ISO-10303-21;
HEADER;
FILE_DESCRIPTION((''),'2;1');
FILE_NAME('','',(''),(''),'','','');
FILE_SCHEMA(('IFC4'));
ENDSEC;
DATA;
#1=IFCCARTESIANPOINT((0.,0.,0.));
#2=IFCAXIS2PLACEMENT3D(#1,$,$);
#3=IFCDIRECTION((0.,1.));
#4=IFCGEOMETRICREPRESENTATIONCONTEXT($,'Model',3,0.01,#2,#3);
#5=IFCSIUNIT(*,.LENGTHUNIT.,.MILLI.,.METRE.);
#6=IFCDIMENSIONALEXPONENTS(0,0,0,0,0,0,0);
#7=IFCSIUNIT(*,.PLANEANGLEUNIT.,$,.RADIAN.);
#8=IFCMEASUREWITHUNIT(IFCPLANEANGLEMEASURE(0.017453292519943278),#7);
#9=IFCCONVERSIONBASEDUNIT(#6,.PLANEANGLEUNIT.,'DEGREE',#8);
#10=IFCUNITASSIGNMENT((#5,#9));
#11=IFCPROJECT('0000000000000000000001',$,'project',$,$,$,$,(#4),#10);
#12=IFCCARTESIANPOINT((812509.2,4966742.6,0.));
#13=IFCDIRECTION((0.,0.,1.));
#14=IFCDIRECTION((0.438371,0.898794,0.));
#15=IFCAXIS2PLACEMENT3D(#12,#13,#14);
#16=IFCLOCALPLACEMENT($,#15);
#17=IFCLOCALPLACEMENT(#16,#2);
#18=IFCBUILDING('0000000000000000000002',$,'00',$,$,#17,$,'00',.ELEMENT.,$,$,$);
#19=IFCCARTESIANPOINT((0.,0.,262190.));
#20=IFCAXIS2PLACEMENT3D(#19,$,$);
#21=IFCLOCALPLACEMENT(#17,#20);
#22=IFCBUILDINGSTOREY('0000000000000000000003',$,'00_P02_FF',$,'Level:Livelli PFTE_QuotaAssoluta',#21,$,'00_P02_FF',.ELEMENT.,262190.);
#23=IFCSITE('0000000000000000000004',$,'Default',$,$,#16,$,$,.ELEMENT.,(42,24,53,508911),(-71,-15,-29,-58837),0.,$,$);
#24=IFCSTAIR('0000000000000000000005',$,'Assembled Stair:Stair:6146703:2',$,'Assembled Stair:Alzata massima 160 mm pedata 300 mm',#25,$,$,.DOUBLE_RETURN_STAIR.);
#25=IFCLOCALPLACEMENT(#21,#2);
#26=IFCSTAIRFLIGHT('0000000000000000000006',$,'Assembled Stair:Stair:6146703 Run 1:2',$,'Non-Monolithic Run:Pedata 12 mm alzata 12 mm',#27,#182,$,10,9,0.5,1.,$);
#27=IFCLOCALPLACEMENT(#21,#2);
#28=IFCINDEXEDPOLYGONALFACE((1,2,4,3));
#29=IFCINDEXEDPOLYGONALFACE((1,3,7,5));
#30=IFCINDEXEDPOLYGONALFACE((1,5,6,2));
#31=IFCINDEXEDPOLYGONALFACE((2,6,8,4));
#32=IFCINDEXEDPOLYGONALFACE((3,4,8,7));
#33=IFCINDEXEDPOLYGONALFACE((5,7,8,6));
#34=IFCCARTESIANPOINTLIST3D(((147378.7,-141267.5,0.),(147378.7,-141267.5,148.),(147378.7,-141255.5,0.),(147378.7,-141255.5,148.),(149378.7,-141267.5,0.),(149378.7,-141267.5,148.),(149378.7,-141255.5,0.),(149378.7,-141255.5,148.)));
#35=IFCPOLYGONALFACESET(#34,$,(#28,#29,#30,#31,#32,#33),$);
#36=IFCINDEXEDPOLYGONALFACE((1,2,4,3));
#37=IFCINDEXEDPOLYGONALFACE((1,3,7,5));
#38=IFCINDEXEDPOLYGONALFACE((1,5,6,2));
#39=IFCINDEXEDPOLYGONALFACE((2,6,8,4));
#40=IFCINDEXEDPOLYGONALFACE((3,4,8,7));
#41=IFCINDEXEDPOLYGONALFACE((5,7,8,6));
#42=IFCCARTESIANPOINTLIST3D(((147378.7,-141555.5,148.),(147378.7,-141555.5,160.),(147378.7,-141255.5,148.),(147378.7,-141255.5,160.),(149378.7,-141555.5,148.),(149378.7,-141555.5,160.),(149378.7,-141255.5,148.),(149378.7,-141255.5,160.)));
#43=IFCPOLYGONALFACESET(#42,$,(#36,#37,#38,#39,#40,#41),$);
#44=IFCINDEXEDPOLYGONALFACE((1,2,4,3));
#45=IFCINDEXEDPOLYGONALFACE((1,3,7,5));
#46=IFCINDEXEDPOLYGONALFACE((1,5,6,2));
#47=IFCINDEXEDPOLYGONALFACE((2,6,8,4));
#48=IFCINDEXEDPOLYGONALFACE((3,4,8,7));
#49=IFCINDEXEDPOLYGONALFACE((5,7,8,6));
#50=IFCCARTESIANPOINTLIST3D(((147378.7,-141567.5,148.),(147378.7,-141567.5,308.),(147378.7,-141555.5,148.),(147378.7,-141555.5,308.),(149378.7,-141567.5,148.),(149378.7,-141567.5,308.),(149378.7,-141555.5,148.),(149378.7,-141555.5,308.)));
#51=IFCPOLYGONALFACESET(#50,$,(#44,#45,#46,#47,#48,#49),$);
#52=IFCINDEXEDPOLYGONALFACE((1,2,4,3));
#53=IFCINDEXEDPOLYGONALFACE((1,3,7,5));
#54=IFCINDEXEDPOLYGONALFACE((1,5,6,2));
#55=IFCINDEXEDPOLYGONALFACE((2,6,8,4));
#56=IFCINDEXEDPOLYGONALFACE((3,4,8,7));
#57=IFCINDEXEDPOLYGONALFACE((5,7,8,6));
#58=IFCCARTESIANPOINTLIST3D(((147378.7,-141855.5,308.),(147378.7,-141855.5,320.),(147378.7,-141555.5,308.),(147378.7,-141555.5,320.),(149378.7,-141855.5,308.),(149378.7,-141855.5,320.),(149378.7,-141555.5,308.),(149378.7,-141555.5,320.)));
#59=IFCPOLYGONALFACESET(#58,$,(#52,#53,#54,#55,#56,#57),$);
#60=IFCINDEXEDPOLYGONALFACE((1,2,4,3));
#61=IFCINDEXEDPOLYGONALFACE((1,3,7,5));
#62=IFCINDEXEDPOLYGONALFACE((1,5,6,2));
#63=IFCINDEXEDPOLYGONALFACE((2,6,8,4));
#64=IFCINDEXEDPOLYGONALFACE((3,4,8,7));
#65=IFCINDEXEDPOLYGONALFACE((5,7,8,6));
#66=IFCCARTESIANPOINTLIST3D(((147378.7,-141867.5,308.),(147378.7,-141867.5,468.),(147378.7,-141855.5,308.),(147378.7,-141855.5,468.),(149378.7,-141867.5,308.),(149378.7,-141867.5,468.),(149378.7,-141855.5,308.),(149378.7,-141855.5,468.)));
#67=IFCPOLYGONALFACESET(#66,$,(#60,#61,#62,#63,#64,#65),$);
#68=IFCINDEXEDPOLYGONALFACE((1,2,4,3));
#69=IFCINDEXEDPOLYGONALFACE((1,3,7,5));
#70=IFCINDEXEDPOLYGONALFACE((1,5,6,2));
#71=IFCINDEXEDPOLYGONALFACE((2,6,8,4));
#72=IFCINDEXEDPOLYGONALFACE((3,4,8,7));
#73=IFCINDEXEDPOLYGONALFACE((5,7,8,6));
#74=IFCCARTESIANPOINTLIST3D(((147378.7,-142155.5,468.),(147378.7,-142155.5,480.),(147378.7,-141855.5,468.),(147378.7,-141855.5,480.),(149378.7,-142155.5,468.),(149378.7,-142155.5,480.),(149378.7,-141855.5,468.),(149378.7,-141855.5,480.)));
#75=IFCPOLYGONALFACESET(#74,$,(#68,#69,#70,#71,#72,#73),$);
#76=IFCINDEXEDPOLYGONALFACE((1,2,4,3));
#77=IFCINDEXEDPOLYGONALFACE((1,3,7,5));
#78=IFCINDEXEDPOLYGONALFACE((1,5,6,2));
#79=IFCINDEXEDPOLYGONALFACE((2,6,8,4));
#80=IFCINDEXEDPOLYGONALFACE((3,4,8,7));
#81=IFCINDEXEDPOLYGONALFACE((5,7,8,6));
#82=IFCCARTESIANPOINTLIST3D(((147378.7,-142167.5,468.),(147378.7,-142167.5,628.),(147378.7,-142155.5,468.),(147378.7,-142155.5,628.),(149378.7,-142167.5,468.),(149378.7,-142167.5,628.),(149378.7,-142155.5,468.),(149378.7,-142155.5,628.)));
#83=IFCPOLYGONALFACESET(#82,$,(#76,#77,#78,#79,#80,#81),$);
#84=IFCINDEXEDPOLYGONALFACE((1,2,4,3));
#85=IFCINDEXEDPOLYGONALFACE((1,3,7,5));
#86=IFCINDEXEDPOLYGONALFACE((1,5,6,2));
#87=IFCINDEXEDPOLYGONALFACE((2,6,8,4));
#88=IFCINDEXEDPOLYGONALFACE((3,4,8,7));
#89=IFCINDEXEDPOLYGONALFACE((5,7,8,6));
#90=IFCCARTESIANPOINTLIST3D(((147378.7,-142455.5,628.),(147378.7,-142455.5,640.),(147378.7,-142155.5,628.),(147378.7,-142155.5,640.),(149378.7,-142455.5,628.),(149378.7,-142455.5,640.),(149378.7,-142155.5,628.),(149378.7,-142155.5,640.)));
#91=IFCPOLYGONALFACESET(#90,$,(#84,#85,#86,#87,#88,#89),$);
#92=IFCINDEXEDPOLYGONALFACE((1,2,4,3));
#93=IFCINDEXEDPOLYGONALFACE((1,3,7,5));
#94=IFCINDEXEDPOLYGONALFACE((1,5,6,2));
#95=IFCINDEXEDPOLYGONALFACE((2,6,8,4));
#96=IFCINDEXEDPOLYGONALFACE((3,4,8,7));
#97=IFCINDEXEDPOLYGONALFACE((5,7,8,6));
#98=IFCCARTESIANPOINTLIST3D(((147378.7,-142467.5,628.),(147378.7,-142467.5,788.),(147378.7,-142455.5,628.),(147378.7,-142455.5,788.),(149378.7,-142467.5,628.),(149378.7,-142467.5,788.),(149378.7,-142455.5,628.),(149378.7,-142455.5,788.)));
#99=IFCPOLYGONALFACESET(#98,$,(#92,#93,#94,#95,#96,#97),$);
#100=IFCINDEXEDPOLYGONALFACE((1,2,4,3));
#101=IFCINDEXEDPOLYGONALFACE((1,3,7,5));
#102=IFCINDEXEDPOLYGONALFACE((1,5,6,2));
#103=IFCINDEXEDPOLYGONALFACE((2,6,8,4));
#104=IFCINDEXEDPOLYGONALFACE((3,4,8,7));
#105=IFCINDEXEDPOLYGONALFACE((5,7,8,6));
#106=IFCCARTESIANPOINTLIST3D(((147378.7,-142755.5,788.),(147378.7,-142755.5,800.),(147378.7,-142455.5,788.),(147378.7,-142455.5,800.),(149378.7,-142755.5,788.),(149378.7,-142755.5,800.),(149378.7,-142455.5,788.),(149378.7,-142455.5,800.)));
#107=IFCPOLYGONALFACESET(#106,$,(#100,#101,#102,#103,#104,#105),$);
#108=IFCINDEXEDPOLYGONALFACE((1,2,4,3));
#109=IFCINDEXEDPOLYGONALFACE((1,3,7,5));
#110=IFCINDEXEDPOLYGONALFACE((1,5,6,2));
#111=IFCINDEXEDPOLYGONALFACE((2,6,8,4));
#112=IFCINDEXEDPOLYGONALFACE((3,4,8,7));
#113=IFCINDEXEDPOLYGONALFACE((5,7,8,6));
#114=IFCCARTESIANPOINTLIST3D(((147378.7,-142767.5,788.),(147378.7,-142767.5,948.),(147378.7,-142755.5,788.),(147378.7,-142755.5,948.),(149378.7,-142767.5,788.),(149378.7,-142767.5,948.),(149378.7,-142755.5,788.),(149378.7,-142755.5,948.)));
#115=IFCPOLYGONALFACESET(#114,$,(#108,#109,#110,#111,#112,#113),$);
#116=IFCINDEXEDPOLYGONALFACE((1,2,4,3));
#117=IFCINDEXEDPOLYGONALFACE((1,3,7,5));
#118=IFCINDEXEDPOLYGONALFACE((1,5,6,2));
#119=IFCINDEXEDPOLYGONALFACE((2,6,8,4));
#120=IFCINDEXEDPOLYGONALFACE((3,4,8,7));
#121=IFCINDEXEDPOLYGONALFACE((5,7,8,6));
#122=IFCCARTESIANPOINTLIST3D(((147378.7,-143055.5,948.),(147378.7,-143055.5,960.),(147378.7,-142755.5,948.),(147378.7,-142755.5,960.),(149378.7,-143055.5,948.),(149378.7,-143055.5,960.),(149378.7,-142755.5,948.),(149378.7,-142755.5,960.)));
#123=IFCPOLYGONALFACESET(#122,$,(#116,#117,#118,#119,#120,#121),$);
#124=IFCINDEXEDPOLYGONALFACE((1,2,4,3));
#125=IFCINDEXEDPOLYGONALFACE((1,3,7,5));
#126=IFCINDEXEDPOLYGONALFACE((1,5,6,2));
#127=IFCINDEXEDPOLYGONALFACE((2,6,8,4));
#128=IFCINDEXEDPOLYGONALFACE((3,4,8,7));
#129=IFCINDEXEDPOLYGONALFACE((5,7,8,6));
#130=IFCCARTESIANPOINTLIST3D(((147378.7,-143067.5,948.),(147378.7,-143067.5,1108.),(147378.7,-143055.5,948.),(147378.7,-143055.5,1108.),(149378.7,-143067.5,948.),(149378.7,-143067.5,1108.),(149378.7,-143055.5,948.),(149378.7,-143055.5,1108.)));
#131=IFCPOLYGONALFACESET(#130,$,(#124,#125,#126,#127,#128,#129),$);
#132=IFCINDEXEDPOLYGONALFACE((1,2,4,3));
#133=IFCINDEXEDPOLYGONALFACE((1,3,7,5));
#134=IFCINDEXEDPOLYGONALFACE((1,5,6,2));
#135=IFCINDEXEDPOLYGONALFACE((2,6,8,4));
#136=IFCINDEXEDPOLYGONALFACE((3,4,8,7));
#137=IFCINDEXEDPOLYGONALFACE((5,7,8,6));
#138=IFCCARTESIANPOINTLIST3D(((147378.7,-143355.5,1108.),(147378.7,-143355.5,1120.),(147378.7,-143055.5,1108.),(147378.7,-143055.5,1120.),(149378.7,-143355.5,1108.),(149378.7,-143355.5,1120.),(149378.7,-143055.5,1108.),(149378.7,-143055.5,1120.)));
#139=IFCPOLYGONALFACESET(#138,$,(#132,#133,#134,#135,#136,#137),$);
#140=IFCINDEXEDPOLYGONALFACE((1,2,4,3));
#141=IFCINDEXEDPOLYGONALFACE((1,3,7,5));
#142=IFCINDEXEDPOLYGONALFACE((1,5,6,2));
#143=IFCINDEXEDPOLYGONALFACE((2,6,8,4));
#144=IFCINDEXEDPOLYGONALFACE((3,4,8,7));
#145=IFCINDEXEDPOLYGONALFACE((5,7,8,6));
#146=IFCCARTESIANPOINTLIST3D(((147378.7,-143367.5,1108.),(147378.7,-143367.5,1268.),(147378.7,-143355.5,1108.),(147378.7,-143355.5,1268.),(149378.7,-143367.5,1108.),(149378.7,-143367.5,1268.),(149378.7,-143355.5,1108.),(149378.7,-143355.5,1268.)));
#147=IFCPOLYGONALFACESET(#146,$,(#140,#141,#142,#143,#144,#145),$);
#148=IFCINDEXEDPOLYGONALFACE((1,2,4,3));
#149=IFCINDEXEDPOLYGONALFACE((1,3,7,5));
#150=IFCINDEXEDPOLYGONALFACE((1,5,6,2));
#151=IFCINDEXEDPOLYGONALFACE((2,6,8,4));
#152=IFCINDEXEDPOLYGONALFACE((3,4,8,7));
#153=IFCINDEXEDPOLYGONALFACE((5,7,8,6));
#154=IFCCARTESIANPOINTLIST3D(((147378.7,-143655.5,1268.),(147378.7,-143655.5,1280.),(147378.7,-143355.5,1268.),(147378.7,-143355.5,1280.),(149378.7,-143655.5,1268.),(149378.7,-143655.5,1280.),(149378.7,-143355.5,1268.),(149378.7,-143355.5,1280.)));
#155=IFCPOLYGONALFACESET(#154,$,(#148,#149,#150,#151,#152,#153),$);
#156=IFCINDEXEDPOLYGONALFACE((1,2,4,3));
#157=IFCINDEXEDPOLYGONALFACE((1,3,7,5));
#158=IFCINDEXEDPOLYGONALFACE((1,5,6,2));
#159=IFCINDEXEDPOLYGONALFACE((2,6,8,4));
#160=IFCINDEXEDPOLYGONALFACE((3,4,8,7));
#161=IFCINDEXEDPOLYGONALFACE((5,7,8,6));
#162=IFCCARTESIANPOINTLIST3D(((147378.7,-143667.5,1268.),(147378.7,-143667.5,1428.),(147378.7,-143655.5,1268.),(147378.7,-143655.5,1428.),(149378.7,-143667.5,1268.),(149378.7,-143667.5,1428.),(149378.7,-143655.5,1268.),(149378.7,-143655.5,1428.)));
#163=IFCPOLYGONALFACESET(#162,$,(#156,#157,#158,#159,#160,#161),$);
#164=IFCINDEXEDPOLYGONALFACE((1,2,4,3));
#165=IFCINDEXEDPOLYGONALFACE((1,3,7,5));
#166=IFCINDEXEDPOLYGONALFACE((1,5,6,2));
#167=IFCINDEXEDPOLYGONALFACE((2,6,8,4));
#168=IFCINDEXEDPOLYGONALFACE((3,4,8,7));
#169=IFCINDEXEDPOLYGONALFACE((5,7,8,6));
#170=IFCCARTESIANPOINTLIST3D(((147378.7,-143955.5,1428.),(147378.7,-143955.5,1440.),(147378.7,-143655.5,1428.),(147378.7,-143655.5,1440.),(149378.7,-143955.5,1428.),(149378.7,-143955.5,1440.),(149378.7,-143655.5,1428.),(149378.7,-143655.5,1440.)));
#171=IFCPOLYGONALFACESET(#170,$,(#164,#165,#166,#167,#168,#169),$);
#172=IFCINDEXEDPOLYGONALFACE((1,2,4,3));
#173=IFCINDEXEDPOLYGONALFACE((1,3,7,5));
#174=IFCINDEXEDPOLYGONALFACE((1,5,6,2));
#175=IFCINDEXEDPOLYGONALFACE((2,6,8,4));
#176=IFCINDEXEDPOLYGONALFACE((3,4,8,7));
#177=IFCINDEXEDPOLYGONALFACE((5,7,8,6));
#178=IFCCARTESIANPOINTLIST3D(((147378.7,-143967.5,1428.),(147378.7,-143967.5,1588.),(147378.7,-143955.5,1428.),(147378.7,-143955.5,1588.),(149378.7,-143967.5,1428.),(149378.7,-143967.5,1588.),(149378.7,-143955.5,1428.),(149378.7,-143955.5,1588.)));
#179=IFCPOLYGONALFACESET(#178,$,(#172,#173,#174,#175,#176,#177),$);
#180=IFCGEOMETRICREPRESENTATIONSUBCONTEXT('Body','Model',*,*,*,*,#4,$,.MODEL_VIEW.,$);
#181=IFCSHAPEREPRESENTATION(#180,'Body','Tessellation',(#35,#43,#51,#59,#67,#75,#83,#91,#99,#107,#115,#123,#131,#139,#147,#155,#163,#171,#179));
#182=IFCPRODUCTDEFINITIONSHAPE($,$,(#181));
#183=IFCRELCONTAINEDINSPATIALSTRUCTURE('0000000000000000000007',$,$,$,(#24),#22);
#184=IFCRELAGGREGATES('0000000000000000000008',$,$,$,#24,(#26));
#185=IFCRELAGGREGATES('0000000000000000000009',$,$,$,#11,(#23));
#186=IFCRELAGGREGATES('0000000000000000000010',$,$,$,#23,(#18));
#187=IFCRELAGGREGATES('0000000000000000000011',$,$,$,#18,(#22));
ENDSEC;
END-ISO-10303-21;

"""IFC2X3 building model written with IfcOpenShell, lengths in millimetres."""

from ifc_helpers import new_model, entity, si_unit, converted_unit, direction, frame, frame_2d, origin, origin_2d_with_axis, place, context, subcontext, project, spatial, rectangle, extrude, element, aggregate, save


model = new_model("IFC2X3")

# Units and contexts
model_context = context("Model", 3, precision=0.01, world=origin(), true_north=direction((0.0, 1.0)))
body_context = subcontext(model_context, "Body", "Model", "MODEL_VIEW")
ifc_project = project(units=[si_unit("LENGTHUNIT", "METRE", prefix="MILLI"), converted_unit("PLANEANGLEUNIT", "DEGREE", entity("IfcPlaneAngleMeasure", 0.017453292519943278), si_unit("PLANEANGLEUNIT", "RADIAN"), dimensions=[0, 0, 0, 0, 0, 0, 0])], contexts=[model_context])

# Site, building, storey
site_placement = place(None, frame((812509.2, 4966742.6, 0.0), z_axis=(0.0, 0.0, 1.0), x_axis=(0.438371, 0.898794, 0.0)))
site = spatial("IfcSite", under=ifc_project, at=site_placement, Name="Default", CompositionType="ELEMENT", RefLatitude=(42, 24, 53, 508911), RefLongitude=(-71, -15, -29, -58837), RefElevation=0.0)
building_placement = place(site_placement, origin())
building = spatial("IfcBuilding", under=site, at=building_placement, Name="00", LongName="00", CompositionType="ELEMENT")
storey_placement = place(building_placement, frame((0.0, 0.0, 262190.0)))
storey = spatial("IfcBuildingStorey", under=building, at=storey_placement, Name="00_P02_FF", ObjectType="Level:Livelli PFTE_QuotaAssoluta", LongName="00_P02_FF", CompositionType="ELEMENT", Elevation=262190.0)

# Stair
stair_1_placement = place(storey_placement, origin())
stair_1 = element("IfcStair", 1, at=stair_1_placement, inside=storey, Name="Assembled Stair:Stair:6146703:2", ObjectType="Assembled Stair:Alzata massima 160 mm pedata 300 mm", ShapeType="DOUBLE_RETURN_STAIR")

# Stair flight
stair_flight_1_placement = place(stair_1_placement, origin())
stair_flight_1 = element("IfcStairFlight", 2, at=stair_flight_1_placement, Name="Assembled Stair:Stair:6146703 Run 1:2", ObjectType="Non-Monolithic Run:Pedata 12 mm alzata 12 mm", NumberOfRiser=10, NumberOfTreads=9, RiserHeight=0.5, TreadLength=1.0, context=body_context, shape_type="SweptSolid", body=[
    extrude(rectangle(XDim=2000.0, YDim=12.0, at=origin_2d_with_axis()), frame((148378.7, -141261.5, 0.0)), (0.0, 0.0, 1.0), 148.0),
    extrude(rectangle(XDim=300.0, YDim=2000.0, at=frame_2d((0.0, 0.0), x_axis=(1.0, 0.0))), frame((148378.7, -141405.5, 148.0), z_axis=(0.0, 0.0, 1.0), x_axis=(0.0, 1.0, 0.0)), (0.0, 0.0, 1.0), 12.0),
    extrude(rectangle(XDim=2000.0, YDim=12.0, at=origin_2d_with_axis()), frame((148378.7, -141561.5, 148.0)), (0.0, 0.0, 1.0), 160.0),
    extrude(rectangle(XDim=300.0, YDim=2000.0, at=origin_2d_with_axis()), frame((148378.7, -141705.5, 308.0), z_axis=(0.0, 0.0, 1.0), x_axis=(0.0, 1.0, 0.0)), (0.0, 0.0, 1.0), 12.0),
    extrude(rectangle(XDim=2000.0, YDim=12.0, at=origin_2d_with_axis()), frame((148378.7, -141861.5, 308.0)), (0.0, 0.0, 1.0), 160.0),
    extrude(rectangle(XDim=300.0, YDim=2000.0, at=origin_2d_with_axis()), frame((148378.7, -142005.5, 468.0), z_axis=(0.0, 0.0, 1.0), x_axis=(0.0, 1.0, 0.0)), (0.0, 0.0, 1.0), 12.0),
    extrude(rectangle(XDim=2000.0, YDim=12.0, at=origin_2d_with_axis()), frame((148378.7, -142161.5, 468.0)), (0.0, 0.0, 1.0), 160.0),
    extrude(rectangle(XDim=300.0, YDim=2000.0, at=origin_2d_with_axis()), frame((148378.7, -142305.5, 628.0), z_axis=(0.0, 0.0, 1.0), x_axis=(0.0, 1.0, 0.0)), (0.0, 0.0, 1.0), 12.0),
    extrude(rectangle(XDim=2000.0, YDim=12.0, at=origin_2d_with_axis()), frame((148378.7, -142461.5, 628.0)), (0.0, 0.0, 1.0), 160.0),
    extrude(rectangle(XDim=300.0, YDim=2000.0, at=origin_2d_with_axis()), frame((148378.7, -142605.5, 788.0), z_axis=(0.0, 0.0, 1.0), x_axis=(0.0, 1.0, 0.0)), (0.0, 0.0, 1.0), 12.0),
    extrude(rectangle(XDim=2000.0, YDim=12.0, at=origin_2d_with_axis()), frame((148378.7, -142761.5, 788.0)), (0.0, 0.0, 1.0), 160.0),
    extrude(rectangle(XDim=300.0, YDim=2000.0, at=origin_2d_with_axis()), frame((148378.7, -142905.5, 948.0), z_axis=(0.0, 0.0, 1.0), x_axis=(0.0, 1.0, 0.0)), (0.0, 0.0, 1.0), 12.0),
    extrude(rectangle(XDim=2000.0, YDim=12.0, at=origin_2d_with_axis()), frame((148378.7, -143061.5, 948.0)), (0.0, 0.0, 1.0), 160.0),
    extrude(rectangle(XDim=300.0, YDim=2000.0, at=origin_2d_with_axis()), frame((148378.7, -143205.5, 1108.0), z_axis=(0.0, 0.0, 1.0), x_axis=(0.0, 1.0, 0.0)), (0.0, 0.0, 1.0), 12.0),
    extrude(rectangle(XDim=2000.0, YDim=12.0, at=origin_2d_with_axis()), frame((148378.7, -143361.5, 1108.0)), (0.0, 0.0, 1.0), 160.0),
    extrude(rectangle(XDim=300.0, YDim=2000.0, at=origin_2d_with_axis()), frame((148378.7, -143505.5, 1268.0), z_axis=(0.0, 0.0, 1.0), x_axis=(0.0, 1.0, 0.0)), (0.0, 0.0, 1.0), 12.0),
    extrude(rectangle(XDim=2000.0, YDim=12.0, at=origin_2d_with_axis()), frame((148378.7, -143661.5, 1268.0)), (0.0, 0.0, 1.0), 160.0),
    extrude(rectangle(XDim=300.0, YDim=2000.0, at=origin_2d_with_axis()), frame((148378.7, -143805.5, 1428.0), z_axis=(0.0, 0.0, 1.0), x_axis=(0.0, 1.0, 0.0)), (0.0, 0.0, 1.0), 12.0),
    extrude(rectangle(XDim=2000.0, YDim=12.0, at=origin_2d_with_axis()), frame((148378.7, -143961.5, 1428.0)), (0.0, 0.0, 1.0), 160.0),
])
aggregate(stair_1, [stair_flight_1])

save(model, "model.ifc")
